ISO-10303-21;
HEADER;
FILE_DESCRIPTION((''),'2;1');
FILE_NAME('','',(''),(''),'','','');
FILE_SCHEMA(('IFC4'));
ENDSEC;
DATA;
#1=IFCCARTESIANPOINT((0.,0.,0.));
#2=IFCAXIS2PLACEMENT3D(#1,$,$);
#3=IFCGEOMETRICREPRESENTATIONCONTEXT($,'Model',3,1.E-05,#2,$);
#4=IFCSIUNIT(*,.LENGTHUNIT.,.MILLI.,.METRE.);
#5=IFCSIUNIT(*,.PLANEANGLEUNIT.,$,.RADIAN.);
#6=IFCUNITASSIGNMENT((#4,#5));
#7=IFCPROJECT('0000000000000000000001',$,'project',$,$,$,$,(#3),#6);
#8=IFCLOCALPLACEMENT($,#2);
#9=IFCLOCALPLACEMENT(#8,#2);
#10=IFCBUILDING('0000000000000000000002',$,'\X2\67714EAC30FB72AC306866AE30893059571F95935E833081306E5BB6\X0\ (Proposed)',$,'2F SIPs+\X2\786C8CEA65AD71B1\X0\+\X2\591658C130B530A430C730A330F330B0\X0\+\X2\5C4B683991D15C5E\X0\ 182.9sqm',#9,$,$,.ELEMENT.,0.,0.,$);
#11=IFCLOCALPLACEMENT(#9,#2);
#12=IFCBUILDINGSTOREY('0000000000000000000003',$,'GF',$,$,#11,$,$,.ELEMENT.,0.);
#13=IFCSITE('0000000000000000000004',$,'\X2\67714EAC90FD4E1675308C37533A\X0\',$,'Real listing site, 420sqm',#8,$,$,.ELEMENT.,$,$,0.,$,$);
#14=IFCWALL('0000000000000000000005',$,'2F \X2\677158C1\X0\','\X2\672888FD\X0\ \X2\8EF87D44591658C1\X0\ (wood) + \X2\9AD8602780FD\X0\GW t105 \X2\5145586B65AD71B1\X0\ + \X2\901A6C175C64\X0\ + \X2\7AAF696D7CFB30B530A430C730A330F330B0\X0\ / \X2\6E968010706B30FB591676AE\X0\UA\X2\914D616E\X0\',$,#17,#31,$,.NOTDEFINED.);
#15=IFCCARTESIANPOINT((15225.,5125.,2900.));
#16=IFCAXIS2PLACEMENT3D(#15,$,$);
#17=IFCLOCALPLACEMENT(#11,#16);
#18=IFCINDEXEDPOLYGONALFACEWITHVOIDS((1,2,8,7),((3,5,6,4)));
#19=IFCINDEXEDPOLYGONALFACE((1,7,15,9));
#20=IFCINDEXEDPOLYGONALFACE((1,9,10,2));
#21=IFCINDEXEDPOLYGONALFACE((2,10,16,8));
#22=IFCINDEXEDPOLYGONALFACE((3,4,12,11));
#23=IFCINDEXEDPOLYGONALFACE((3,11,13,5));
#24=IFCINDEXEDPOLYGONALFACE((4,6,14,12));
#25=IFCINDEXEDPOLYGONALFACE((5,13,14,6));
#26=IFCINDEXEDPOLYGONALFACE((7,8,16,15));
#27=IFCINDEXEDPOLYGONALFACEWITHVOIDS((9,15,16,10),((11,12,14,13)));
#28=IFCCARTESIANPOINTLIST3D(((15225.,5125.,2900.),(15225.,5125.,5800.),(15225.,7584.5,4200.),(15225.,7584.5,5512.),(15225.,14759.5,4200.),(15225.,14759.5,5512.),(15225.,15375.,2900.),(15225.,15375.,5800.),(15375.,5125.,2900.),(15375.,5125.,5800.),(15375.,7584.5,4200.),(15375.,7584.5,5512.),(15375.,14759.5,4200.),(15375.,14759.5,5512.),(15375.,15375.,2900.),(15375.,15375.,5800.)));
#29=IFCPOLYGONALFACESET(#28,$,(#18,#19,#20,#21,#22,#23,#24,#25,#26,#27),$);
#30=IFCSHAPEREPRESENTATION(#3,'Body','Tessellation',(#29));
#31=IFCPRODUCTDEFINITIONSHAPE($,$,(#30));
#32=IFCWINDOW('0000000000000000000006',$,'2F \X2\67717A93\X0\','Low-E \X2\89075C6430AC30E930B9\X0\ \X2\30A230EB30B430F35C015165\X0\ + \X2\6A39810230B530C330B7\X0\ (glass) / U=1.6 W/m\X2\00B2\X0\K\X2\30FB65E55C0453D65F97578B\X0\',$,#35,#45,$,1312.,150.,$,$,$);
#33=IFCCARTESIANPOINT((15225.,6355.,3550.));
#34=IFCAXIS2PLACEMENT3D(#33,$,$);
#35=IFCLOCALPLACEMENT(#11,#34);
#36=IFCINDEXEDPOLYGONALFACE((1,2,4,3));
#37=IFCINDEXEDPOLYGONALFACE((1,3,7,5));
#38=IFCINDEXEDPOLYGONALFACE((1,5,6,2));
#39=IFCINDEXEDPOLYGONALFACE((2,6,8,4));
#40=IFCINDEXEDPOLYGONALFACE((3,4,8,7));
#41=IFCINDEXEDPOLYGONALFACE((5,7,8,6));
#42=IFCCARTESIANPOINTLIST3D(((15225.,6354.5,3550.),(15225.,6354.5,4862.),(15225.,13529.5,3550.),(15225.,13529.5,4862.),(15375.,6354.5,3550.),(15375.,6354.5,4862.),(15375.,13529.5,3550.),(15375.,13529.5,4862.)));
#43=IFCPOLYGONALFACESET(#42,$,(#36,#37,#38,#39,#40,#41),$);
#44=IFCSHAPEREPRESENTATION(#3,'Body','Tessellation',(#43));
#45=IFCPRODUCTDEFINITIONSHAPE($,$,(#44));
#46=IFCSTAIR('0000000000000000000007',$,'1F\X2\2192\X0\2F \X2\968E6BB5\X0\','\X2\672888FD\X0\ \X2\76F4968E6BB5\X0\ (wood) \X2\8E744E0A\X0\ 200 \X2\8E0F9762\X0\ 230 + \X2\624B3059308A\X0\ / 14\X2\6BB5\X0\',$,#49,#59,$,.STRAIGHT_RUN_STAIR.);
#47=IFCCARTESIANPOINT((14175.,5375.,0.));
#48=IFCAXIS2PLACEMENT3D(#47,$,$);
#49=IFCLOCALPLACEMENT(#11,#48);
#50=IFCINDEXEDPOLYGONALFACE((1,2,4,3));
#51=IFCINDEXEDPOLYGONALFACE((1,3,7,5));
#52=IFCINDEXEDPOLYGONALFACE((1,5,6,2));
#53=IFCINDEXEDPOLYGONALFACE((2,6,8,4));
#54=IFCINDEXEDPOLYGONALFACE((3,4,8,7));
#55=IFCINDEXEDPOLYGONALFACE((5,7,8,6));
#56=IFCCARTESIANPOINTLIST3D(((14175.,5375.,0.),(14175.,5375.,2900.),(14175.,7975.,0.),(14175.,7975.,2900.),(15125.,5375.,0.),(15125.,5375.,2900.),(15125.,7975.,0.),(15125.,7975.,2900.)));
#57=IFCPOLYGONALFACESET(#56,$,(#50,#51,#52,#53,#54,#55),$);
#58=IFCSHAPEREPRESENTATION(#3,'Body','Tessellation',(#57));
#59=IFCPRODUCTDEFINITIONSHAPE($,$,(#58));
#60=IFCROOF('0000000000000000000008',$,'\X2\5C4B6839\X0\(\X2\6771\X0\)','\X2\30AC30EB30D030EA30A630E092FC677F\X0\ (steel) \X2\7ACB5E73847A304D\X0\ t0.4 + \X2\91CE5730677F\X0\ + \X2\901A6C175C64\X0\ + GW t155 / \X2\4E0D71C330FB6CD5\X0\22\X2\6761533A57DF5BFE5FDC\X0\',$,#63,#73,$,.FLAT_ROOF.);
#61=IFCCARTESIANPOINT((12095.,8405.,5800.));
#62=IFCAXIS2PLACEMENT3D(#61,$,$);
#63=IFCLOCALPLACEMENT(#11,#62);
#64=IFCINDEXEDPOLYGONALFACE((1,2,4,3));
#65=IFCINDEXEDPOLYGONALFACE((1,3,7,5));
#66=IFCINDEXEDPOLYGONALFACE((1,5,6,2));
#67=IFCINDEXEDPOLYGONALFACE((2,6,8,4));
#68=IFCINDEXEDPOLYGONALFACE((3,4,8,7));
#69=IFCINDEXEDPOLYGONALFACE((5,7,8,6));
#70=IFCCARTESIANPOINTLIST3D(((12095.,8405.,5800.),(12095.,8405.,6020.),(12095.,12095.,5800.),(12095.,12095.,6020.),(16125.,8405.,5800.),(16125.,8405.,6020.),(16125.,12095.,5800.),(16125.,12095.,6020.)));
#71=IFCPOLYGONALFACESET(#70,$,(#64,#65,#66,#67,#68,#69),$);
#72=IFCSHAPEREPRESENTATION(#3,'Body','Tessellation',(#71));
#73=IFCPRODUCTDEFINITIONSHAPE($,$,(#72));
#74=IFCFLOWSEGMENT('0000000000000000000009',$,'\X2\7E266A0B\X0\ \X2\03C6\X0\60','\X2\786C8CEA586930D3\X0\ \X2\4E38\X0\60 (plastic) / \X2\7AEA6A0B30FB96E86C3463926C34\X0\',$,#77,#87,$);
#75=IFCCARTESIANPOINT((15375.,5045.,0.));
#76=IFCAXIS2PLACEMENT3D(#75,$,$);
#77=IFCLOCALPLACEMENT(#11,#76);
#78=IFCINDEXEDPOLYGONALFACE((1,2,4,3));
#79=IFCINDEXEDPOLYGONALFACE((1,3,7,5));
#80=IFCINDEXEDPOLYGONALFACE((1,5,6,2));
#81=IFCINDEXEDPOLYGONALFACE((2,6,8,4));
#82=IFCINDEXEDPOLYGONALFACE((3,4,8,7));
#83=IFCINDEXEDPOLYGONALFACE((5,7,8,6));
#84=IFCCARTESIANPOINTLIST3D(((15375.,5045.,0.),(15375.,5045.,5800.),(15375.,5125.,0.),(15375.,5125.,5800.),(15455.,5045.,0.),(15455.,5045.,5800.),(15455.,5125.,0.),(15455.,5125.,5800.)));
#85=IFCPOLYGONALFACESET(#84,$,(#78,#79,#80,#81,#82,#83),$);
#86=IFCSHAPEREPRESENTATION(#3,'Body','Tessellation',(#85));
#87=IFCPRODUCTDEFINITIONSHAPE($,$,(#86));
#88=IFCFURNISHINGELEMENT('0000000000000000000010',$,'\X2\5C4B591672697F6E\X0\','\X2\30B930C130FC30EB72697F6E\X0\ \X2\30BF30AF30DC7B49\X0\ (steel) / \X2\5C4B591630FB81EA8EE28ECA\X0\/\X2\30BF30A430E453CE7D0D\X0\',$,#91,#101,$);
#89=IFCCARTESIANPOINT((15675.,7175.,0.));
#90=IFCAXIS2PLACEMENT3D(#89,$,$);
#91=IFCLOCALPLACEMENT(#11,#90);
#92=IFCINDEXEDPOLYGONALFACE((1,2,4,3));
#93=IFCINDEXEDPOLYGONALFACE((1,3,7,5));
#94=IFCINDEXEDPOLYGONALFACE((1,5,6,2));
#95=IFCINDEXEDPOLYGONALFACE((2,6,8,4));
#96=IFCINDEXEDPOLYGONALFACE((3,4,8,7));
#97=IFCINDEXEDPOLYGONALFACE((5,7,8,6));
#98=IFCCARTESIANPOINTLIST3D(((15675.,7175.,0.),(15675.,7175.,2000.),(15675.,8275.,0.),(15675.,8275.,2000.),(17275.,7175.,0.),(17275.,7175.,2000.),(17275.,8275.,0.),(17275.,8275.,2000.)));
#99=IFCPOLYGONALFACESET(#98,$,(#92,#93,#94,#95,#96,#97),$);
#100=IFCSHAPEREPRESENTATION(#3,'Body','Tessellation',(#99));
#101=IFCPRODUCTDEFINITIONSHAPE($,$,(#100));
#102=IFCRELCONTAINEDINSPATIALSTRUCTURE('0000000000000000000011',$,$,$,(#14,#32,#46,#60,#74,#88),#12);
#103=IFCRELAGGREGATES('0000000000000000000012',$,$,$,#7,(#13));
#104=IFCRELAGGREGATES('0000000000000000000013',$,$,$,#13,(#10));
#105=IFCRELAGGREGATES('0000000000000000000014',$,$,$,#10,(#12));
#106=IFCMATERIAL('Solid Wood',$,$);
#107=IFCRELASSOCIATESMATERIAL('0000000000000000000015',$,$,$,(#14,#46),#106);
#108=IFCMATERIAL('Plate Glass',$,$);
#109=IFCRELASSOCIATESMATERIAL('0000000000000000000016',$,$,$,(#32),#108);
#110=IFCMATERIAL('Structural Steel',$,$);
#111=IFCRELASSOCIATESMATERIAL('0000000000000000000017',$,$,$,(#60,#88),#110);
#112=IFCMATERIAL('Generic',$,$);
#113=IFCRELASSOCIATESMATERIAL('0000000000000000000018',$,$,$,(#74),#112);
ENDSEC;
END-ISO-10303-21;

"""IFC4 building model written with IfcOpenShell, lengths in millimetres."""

from ifc_helpers import new_model, si_unit, frame, frame_2d, origin, place, context, project, spatial, rectangle, extrude, material, element, fill, save


model = new_model("IFC4")

# Units and contexts
model_context = context("Model", 3, precision=1e-05, world=origin())
ifc_project = project(units=[si_unit("LENGTHUNIT", "METRE", prefix="MILLI"), si_unit("PLANEANGLEUNIT", "RADIAN")], contexts=[model_context])

# Site, building, storey
site_placement = place(None, origin())
site = spatial("IfcSite", under=ifc_project, at=site_placement, Name="東京都世田谷区", ObjectType="Real listing site, 420sqm", CompositionType="ELEMENT", RefElevation=0.0)
building_placement = place(site_placement, origin())
building = spatial("IfcBuilding", under=site, at=building_placement, Name="東京・犬と暮らす土間広めの家 (Proposed)", ObjectType="2F SIPs+硬質断熱+外壁サイディング+屋根金属 182.9sqm", CompositionType="ELEMENT", ElevationOfRefHeight=0.0, ElevationOfTerrain=0.0)
storey_placement = place(building_placement, origin())
storey = spatial("IfcBuildingStorey", under=building, at=storey_placement, Name="GF", CompositionType="ELEMENT", Elevation=0.0)

# Shared definitions
ifc_material_1 = material(Name="Solid Wood")

# Wall, opening, window
ifc_material_2 = material(Name="Plate Glass")
wall_1_placement = place(storey_placement, frame((15225.0, 5125.0, 2900.0)))
wall_1 = element("IfcWall", 1, at=wall_1_placement, inside=storey, material=ifc_material_1, Name="2F 東壁", Description="木製 軸組外壁 (wood) + 高性能GW t105 充填断熱 + 通気層 + 窯業系サイディング / 準耐火・外皮UA配慮", PredefinedType="NOTDEFINED", context=model_context, shape_type="SweptSolid", body=[
    extrude(rectangle(XDim=150.0, YDim=10250.0, at=frame_2d((75.0, 5125.0))), frame((15225.0, 5125.0, 2900.0)), (0.0, 0.0, 1.0), 2900.0),
])
opening_1_placement = place(storey_placement, frame((15225.0, 6355.0, 3550.0)))
opening_1 = element("IfcOpeningElement", 2, at=opening_1_placement, cuts=wall_1, PredefinedType="NOTDEFINED", context=model_context, shape_type="SweptSolid", body=[
    extrude(rectangle(XDim=150.0, YDim=7175.0, at=frame_2d((75.0, 3587.0))), frame((15225.0, 6355.0, 3550.0)), (0.0, 0.0, 1.0), 1312.0),
])
window_1_placement = place(storey_placement, frame((15225.0, 6355.0, 3550.0)))
window_1 = element("IfcWindow", 3, at=window_1_placement, inside=storey, material=ifc_material_2, Name="2F 東窓", Description="Low-E 複層ガラス アルゴン封入 + 樹脂サッシ (glass) / U=1.6 W/m²K・日射取得型", OverallHeight=1312.0, OverallWidth=150.0, context=model_context, shape_type="SweptSolid", body=[
    extrude(rectangle(XDim=150.0, YDim=7175.0, at=frame_2d((75.0, 3587.0))), frame((15225.0, 6355.0, 3550.0)), (0.0, 0.0, 1.0), 1312.0),
])
fill(opening_1, window_1)

# Stair
stair_placement = place(storey_placement, frame((14175.0, 5375.0, 0.0)))
element("IfcStair", 4, at=stair_placement, inside=storey, material=ifc_material_1, Name="1F→2F 階段", Description="木製 直階段 (wood) 蹴上 200 踏面 230 + 手すり / 14段", PredefinedType="STRAIGHT_RUN_STAIR", context=model_context, shape_type="SweptSolid", body=[
    extrude(rectangle(XDim=950.0, YDim=2600.0, at=frame_2d((475.0, 1300.0))), frame((14175.0, 5375.0, 0.0)), (0.0, 0.0, 1.0), 2900.0),
])

# Roof
ifc_material_3 = material(Name="Structural Steel")
roof_placement = place(storey_placement, frame((12095.0, 8405.0, 5800.0)))
element("IfcRoof", 5, at=roof_placement, inside=storey, material=ifc_material_3, Name="屋根(東)", Description="ガルバリウム鋼板 (steel) 立平葺き t0.4 + 野地板 + 通気層 + GW t155 / 不燃・法22条区域対応", PredefinedType="FLAT_ROOF", context=model_context, shape_type="SweptSolid", body=[
    extrude(rectangle(XDim=4030.0, YDim=3690.0, at=frame_2d((2015.0, 1845.0))), frame((12095.0, 8405.0, 5800.0)), (0.0, 0.0, 1.0), 220.0),
])

# Flow segment
ifc_material_4 = material(Name="Generic")
flow_segment_placement = place(storey_placement, frame((15375.0, 5045.0, 0.0)))
element("IfcFlowSegment", 6, at=flow_segment_placement, inside=storey, material=ifc_material_4, Name="縦樋 φ60", Description="硬質塩ビ 丸60 (plastic) / 竪樋・雨水排水", context=model_context, shape_type="SweptSolid", body=[
    extrude(rectangle(XDim=80.0, YDim=80.0, at=frame_2d((40.0, 40.0))), frame((15375.0, 5045.0, 0.0)), (0.0, 0.0, 1.0), 5800.0),
])

# Furnishing element
furnishing_placement = place(storey_placement, frame((15675.0, 7175.0, 0.0)))
element("IfcFurnishingElement", 7, at=furnishing_placement, inside=storey, material=ifc_material_3, Name="屋外物置", Description="スチール物置 タクボ等 (steel) / 屋外・自転車/タイヤ収納", context=model_context, shape_type="SweptSolid", body=[
    extrude(rectangle(XDim=1600.0, YDim=1100.0, at=frame_2d((800.0, 550.0))), frame((15675.0, 7175.0, 0.0)), (0.0, 0.0, 1.0), 2000.0),
])

save(model, "model.ifc")
